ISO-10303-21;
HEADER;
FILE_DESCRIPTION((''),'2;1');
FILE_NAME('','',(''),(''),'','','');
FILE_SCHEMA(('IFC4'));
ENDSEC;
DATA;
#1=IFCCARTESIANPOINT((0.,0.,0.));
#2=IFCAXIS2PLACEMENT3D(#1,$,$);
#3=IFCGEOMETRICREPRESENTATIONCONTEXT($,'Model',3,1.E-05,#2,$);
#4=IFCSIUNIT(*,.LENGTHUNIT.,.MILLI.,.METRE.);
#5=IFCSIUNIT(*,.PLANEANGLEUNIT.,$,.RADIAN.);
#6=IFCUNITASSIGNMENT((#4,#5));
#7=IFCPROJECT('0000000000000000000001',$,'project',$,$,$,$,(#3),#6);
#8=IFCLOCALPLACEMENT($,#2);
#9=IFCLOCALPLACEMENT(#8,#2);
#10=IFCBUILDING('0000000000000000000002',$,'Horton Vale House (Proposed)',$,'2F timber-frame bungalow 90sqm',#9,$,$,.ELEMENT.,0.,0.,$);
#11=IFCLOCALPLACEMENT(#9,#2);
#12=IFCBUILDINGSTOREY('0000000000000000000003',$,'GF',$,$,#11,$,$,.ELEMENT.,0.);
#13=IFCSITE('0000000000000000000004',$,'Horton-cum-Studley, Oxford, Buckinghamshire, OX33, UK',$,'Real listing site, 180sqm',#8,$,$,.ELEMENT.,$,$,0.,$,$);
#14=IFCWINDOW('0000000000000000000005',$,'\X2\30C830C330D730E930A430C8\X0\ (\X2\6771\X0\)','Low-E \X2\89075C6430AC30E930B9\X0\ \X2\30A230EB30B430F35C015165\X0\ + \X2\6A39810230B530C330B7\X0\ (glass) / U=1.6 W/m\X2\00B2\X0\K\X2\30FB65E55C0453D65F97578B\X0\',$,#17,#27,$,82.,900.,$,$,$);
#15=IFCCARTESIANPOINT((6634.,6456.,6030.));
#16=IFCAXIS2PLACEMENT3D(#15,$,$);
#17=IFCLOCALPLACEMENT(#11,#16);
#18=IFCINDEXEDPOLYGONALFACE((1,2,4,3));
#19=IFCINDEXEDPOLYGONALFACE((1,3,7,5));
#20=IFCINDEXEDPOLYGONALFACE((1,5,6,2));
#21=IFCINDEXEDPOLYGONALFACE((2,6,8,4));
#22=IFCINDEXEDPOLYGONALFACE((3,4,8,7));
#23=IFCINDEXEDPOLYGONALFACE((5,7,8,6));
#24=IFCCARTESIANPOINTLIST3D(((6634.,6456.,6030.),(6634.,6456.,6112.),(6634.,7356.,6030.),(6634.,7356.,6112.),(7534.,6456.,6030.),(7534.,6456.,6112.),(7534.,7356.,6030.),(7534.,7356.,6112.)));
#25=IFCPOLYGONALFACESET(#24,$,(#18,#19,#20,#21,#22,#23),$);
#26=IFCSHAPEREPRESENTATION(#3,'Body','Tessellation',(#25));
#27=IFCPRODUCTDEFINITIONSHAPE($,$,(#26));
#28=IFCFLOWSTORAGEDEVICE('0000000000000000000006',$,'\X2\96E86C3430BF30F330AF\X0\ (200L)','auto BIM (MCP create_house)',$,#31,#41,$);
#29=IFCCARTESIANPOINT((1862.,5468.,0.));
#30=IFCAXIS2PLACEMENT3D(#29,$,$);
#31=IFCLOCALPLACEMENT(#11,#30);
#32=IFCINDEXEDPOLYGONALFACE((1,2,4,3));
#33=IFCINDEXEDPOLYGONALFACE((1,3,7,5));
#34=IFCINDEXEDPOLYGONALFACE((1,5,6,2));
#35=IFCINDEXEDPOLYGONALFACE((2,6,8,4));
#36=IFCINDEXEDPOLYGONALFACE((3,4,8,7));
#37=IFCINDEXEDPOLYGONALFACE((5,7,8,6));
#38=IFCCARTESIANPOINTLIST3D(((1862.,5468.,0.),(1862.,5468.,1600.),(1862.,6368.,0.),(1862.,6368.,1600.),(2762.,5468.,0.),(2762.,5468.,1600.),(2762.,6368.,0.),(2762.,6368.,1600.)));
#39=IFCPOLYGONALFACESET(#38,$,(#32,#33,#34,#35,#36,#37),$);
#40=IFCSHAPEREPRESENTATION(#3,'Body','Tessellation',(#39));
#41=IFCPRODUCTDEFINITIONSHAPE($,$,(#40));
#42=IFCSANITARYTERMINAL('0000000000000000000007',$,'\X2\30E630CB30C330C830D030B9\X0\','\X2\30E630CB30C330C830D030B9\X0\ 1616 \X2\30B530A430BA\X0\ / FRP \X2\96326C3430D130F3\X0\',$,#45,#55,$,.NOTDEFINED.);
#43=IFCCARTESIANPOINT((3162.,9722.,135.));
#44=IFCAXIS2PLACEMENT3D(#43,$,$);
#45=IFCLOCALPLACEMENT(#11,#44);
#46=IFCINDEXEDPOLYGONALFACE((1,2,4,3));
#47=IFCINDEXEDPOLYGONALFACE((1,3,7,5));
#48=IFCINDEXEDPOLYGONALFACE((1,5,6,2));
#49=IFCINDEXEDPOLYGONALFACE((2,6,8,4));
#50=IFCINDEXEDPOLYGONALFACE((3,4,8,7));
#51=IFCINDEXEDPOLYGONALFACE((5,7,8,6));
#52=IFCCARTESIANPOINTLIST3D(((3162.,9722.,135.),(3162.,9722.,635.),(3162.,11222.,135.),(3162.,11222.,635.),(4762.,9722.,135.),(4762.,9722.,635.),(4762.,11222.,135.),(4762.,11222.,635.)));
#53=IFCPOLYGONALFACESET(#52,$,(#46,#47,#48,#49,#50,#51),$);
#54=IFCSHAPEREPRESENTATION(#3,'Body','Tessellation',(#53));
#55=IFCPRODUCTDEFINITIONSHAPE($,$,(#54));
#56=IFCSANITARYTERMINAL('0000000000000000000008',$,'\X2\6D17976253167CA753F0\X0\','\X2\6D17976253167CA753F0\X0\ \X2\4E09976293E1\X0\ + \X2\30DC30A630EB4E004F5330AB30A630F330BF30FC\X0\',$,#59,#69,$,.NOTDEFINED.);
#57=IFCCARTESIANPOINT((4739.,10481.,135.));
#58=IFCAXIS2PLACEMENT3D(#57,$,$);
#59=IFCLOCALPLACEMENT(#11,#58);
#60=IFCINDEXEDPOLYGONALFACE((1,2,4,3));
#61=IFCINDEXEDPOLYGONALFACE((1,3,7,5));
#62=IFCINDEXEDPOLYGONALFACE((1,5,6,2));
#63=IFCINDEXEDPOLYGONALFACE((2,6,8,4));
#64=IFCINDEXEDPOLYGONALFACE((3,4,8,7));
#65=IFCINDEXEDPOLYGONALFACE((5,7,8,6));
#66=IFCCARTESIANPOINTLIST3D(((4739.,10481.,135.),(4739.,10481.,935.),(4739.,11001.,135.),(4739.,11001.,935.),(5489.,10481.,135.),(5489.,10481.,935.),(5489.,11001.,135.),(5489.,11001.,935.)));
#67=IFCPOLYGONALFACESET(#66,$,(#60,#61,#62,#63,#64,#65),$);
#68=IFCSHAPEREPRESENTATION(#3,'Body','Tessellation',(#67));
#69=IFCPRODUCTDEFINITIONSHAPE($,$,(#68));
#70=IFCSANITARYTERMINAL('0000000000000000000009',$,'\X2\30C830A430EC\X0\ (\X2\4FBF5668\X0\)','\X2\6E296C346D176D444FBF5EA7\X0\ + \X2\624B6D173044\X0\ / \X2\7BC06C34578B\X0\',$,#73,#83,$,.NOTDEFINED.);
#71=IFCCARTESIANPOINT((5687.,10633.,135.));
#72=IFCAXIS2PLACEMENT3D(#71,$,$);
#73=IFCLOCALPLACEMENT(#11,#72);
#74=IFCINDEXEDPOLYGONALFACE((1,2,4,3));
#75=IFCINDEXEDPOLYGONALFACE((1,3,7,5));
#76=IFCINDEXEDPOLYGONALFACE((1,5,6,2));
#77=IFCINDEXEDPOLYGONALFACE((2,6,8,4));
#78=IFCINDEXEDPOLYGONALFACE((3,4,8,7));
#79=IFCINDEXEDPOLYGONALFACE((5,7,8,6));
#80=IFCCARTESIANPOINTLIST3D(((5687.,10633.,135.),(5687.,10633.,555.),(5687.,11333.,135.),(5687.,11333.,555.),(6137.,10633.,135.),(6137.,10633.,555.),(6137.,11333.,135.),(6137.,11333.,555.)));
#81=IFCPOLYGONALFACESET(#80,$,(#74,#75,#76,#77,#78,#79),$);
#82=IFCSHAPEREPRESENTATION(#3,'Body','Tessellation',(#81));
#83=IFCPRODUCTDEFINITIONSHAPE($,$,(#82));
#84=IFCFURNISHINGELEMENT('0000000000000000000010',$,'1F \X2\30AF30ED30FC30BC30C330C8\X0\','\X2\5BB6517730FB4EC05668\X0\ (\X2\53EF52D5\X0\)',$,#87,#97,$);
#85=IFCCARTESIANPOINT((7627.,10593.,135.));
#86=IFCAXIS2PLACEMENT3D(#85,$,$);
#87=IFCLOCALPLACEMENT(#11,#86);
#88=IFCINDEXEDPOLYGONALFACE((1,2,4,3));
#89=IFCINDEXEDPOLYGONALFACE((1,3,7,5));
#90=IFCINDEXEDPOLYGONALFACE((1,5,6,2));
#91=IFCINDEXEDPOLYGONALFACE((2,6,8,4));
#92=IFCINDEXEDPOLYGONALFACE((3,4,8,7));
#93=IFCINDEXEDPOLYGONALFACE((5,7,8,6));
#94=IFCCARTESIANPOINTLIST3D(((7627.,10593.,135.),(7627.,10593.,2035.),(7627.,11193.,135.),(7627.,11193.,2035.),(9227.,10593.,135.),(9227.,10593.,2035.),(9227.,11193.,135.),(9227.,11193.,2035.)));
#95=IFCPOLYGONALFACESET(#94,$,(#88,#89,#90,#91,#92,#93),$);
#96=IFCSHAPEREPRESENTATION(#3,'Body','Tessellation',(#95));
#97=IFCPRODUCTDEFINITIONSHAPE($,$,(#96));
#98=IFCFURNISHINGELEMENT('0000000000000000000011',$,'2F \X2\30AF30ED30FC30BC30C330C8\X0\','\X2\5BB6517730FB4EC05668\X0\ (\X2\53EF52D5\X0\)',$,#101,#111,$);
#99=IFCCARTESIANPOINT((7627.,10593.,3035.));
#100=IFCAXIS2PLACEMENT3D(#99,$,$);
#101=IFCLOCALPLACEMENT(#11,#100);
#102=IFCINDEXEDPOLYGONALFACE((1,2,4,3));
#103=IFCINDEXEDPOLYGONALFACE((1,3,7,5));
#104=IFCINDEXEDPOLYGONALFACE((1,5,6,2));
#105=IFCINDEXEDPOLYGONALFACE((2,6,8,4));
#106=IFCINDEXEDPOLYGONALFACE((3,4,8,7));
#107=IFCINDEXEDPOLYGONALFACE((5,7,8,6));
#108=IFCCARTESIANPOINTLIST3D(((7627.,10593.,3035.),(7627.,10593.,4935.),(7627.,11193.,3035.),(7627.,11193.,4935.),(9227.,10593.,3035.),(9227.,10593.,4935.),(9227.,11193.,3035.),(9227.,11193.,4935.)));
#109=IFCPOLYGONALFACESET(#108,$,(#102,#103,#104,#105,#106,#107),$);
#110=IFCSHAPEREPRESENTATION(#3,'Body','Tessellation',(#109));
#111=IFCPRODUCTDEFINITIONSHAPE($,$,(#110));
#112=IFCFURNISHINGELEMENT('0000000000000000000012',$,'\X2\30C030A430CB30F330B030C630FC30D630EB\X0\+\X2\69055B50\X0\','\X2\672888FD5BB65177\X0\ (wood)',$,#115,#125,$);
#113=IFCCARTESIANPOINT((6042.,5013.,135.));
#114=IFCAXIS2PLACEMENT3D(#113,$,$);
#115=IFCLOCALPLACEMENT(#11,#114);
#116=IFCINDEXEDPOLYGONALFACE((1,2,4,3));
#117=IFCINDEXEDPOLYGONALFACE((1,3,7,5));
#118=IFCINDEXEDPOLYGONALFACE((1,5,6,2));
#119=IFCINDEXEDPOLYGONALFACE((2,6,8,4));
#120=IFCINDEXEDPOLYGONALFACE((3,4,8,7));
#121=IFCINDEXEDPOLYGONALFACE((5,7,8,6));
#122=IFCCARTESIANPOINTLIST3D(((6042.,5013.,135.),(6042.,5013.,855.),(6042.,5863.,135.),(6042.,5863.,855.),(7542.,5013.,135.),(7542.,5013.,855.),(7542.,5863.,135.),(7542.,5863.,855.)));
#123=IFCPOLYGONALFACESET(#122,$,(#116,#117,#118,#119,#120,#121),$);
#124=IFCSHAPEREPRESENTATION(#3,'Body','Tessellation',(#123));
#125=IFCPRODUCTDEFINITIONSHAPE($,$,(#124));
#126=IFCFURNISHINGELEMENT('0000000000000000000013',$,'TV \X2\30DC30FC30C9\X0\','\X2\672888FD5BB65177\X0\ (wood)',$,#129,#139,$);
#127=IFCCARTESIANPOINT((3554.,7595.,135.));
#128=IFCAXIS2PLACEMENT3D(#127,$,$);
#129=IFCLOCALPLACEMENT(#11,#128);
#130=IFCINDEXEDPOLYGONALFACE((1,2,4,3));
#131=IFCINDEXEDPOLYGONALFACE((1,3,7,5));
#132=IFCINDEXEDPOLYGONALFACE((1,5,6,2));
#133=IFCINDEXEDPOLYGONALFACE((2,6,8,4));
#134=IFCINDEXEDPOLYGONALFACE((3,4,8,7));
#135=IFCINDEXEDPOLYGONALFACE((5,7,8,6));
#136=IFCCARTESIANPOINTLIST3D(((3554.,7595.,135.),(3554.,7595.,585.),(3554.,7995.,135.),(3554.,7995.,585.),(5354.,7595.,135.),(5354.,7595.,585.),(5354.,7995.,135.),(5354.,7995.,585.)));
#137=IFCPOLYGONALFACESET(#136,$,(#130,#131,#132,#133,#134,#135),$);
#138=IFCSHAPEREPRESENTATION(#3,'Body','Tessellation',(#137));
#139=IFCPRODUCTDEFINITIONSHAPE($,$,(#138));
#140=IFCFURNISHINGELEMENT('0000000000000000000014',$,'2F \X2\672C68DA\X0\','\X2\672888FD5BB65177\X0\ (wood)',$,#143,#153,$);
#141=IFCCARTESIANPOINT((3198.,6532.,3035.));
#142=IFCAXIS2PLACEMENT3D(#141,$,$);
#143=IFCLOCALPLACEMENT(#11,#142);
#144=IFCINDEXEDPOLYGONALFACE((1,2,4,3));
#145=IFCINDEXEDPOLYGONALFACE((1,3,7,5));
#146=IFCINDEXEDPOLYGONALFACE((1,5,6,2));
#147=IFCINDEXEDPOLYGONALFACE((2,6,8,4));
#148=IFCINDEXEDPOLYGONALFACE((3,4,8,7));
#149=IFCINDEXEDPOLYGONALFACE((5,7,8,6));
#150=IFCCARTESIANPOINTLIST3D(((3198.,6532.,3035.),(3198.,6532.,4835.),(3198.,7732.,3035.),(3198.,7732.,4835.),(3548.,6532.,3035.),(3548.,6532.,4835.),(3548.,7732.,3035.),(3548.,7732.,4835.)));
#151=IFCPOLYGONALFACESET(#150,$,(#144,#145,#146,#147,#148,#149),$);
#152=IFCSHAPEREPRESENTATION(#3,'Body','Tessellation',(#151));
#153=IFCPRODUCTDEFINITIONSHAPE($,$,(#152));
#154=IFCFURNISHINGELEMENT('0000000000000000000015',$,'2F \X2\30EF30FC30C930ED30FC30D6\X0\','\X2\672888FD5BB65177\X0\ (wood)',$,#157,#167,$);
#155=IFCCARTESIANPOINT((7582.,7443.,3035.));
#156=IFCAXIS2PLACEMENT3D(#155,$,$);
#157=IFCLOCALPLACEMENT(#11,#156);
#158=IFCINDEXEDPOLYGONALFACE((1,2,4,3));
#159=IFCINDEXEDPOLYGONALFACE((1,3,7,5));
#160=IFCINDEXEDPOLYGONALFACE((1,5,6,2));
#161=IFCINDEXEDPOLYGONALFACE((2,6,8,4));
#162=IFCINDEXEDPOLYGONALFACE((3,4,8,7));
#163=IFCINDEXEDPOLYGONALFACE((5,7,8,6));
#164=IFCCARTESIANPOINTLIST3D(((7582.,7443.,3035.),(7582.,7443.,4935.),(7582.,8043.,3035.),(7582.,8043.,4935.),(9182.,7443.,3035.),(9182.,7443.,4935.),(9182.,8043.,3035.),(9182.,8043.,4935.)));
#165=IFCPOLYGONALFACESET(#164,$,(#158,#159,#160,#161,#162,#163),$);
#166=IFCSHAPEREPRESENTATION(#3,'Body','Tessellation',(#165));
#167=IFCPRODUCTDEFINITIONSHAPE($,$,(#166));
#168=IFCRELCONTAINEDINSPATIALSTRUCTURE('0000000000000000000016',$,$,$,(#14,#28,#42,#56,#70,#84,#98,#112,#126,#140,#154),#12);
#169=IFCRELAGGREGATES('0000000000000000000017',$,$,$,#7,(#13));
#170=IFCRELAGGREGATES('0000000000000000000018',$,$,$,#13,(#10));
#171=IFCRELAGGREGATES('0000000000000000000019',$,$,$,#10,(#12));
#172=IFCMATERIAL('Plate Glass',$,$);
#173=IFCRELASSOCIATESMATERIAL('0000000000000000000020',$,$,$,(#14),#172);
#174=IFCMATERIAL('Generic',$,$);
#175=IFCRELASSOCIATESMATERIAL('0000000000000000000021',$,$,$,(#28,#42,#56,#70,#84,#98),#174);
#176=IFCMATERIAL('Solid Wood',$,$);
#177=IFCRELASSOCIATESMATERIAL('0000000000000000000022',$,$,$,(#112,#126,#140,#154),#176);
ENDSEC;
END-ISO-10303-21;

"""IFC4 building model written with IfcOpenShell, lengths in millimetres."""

from ifc_helpers import new_model, si_unit, frame, frame_2d, origin, place, context, project, spatial, rectangle, extrude, material, element, save


model = new_model("IFC4")

# Units and contexts
model_context = context("Model", 3, precision=1e-05, world=origin())
ifc_project = project(units=[si_unit("LENGTHUNIT", "METRE", prefix="MILLI"), si_unit("PLANEANGLEUNIT", "RADIAN")], contexts=[model_context])

# Site, building, storey
site_placement = place(None, origin())
site = spatial("IfcSite", under=ifc_project, at=site_placement, Name="Horton-cum-Studley, Oxford, Buckinghamshire, OX33, UK", ObjectType="Real listing site, 180sqm", CompositionType="ELEMENT", RefElevation=0.0)
building_placement = place(site_placement, origin())
building = spatial("IfcBuilding", under=site, at=building_placement, Name="Horton Vale House (Proposed)", ObjectType="2F timber-frame bungalow 90sqm", CompositionType="ELEMENT", ElevationOfRefHeight=0.0, ElevationOfTerrain=0.0)
storey_placement = place(building_placement, origin())
storey = spatial("IfcBuildingStorey", under=building, at=storey_placement, Name="GF", CompositionType="ELEMENT", Elevation=0.0)

# Shared definitions
ifc_material_1 = material(Name="Solid Wood")
ifc_material_2 = material(Name="Plate Glass")

# Window
window_1_placement = place(storey_placement, frame((6634.0, 6456.0, 6030.0)))
element("IfcWindow", 1, at=window_1_placement, inside=storey, material=ifc_material_2, Name="トップライト (東)", Description="Low-E 複層ガラス アルゴン封入 + 樹脂サッシ (glass) / U=1.6 W/m²K・日射取得型", OverallHeight=82.0, OverallWidth=900.0, context=model_context, shape_type="SweptSolid", body=[
    extrude(rectangle(XDim=900.0, YDim=900.0, at=frame_2d((450.0, 450.0))), frame((6634.0, 6456.0, 6030.0)), (0.0, 0.0, 1.0), 82.0),
])

# Flow storage device
ifc_material_3 = material(Name="Generic")
flow_storage_device_placement = place(storey_placement, frame((1862.0, 5468.0, 0.0)))
element("IfcFlowStorageDevice", 2, at=flow_storage_device_placement, inside=storey, material=ifc_material_3, Name="雨水タンク (200L)", Description="auto BIM (MCP create_house)", context=model_context, shape_type="SweptSolid", body=[
    extrude(rectangle(XDim=900.0, YDim=900.0, at=frame_2d((450.0, 450.0))), frame((1862.0, 5468.0, 0.0)), (0.0, 0.0, 1.0), 1600.0),
])

# Sanitary terminals
sanitary_terminal_1_placement = place(storey_placement, frame((3162.0, 9722.0, 135.0)))
element("IfcSanitaryTerminal", 3, at=sanitary_terminal_1_placement, inside=storey, material=ifc_material_3, Name="ユニットバス", Description="ユニットバス 1616 サイズ / FRP 防水パン", PredefinedType="NOTDEFINED", context=model_context, shape_type="SweptSolid", body=[
    extrude(rectangle(XDim=1600.0, YDim=1500.0, at=frame_2d((800.0, 750.0))), frame((3162.0, 9722.0, 135.0)), (0.0, 0.0, 1.0), 500.0),
])
sanitary_terminal_2_placement = place(storey_placement, frame((4739.0, 10481.0, 135.0)))
element("IfcSanitaryTerminal", 4, at=sanitary_terminal_2_placement, inside=storey, material=ifc_material_3, Name="洗面化粧台", Description="洗面化粧台 三面鏡 + ボウル一体カウンター", PredefinedType="NOTDEFINED", context=model_context, shape_type="SweptSolid", body=[
    extrude(rectangle(XDim=750.0, YDim=520.0, at=frame_2d((375.0, 260.0))), frame((4739.0, 10481.0, 135.0)), (0.0, 0.0, 1.0), 800.0),
])
sanitary_terminal_3_placement = place(storey_placement, frame((5687.0, 10633.0, 135.0)))
element("IfcSanitaryTerminal", 5, at=sanitary_terminal_3_placement, inside=storey, material=ifc_material_3, Name="トイレ (便器)", Description="温水洗浄便座 + 手洗い / 節水型", PredefinedType="NOTDEFINED", context=model_context, shape_type="SweptSolid", body=[
    extrude(rectangle(XDim=450.0, YDim=700.0, at=frame_2d((225.0, 350.0))), frame((5687.0, 10633.0, 135.0)), (0.0, 0.0, 1.0), 420.0),
])

# Furnishing elements
furnishing_1_placement = place(storey_placement, frame((7627.0, 10593.0, 135.0)))
element("IfcFurnishingElement", 6, at=furnishing_1_placement, inside=storey, material=ifc_material_3, Name="1F クローゼット", Description="家具・什器 (可動)", context=model_context, shape_type="SweptSolid", body=[
    extrude(rectangle(XDim=1600.0, YDim=600.0, at=frame_2d((800.0, 300.0))), frame((7627.0, 10593.0, 135.0)), (0.0, 0.0, 1.0), 1900.0),
])
furnishing_2_placement = place(storey_placement, frame((7627.0, 10593.0, 3035.0)))
element("IfcFurnishingElement", 7, at=furnishing_2_placement, inside=storey, material=ifc_material_3, Name="2F クローゼット", Description="家具・什器 (可動)", context=model_context, shape_type="SweptSolid", body=[
    extrude(rectangle(XDim=1600.0, YDim=600.0, at=frame_2d((800.0, 300.0))), frame((7627.0, 10593.0, 3035.0)), (0.0, 0.0, 1.0), 1900.0),
])
furnishing_3_placement = place(storey_placement, frame((6042.0, 5013.0, 135.0)))
element("IfcFurnishingElement", 8, at=furnishing_3_placement, inside=storey, material=ifc_material_1, Name="ダイニングテーブル+椅子", Description="木製家具 (wood)", context=model_context, shape_type="SweptSolid", body=[
    extrude(rectangle(XDim=1500.0, YDim=850.0, at=frame_2d((750.0, 425.0))), frame((6042.0, 5013.0, 135.0)), (0.0, 0.0, 1.0), 720.0),
])
furnishing_4_placement = place(storey_placement, frame((3554.0, 7595.0, 135.0)))
element("IfcFurnishingElement", 9, at=furnishing_4_placement, inside=storey, material=ifc_material_1, Name="TV ボード", Description="木製家具 (wood)", context=model_context, shape_type="SweptSolid", body=[
    extrude(rectangle(XDim=1800.0, YDim=400.0, at=frame_2d((900.0, 200.0))), frame((3554.0, 7595.0, 135.0)), (0.0, 0.0, 1.0), 450.0),
])
furnishing_5_placement = place(storey_placement, frame((3198.0, 6532.0, 3035.0)))
element("IfcFurnishingElement", 10, at=furnishing_5_placement, inside=storey, material=ifc_material_1, Name="2F 本棚", Description="木製家具 (wood)", context=model_context, shape_type="SweptSolid", body=[
    extrude(rectangle(XDim=350.0, YDim=1200.0, at=frame_2d((175.0, 600.0))), frame((3198.0, 6532.0, 3035.0)), (0.0, 0.0, 1.0), 1800.0),
])
furnishing_6_placement = place(storey_placement, frame((7582.0, 7443.0, 3035.0)))
element("IfcFurnishingElement", 11, at=furnishing_6_placement, inside=storey, material=ifc_material_1, Name="2F ワードローブ", Description="木製家具 (wood)", context=model_context, shape_type="SweptSolid", body=[
    extrude(rectangle(XDim=1600.0, YDim=600.0, at=frame_2d((800.0, 300.0))), frame((7582.0, 7443.0, 3035.0)), (0.0, 0.0, 1.0), 1900.0),
])

save(model, "model.ifc")
